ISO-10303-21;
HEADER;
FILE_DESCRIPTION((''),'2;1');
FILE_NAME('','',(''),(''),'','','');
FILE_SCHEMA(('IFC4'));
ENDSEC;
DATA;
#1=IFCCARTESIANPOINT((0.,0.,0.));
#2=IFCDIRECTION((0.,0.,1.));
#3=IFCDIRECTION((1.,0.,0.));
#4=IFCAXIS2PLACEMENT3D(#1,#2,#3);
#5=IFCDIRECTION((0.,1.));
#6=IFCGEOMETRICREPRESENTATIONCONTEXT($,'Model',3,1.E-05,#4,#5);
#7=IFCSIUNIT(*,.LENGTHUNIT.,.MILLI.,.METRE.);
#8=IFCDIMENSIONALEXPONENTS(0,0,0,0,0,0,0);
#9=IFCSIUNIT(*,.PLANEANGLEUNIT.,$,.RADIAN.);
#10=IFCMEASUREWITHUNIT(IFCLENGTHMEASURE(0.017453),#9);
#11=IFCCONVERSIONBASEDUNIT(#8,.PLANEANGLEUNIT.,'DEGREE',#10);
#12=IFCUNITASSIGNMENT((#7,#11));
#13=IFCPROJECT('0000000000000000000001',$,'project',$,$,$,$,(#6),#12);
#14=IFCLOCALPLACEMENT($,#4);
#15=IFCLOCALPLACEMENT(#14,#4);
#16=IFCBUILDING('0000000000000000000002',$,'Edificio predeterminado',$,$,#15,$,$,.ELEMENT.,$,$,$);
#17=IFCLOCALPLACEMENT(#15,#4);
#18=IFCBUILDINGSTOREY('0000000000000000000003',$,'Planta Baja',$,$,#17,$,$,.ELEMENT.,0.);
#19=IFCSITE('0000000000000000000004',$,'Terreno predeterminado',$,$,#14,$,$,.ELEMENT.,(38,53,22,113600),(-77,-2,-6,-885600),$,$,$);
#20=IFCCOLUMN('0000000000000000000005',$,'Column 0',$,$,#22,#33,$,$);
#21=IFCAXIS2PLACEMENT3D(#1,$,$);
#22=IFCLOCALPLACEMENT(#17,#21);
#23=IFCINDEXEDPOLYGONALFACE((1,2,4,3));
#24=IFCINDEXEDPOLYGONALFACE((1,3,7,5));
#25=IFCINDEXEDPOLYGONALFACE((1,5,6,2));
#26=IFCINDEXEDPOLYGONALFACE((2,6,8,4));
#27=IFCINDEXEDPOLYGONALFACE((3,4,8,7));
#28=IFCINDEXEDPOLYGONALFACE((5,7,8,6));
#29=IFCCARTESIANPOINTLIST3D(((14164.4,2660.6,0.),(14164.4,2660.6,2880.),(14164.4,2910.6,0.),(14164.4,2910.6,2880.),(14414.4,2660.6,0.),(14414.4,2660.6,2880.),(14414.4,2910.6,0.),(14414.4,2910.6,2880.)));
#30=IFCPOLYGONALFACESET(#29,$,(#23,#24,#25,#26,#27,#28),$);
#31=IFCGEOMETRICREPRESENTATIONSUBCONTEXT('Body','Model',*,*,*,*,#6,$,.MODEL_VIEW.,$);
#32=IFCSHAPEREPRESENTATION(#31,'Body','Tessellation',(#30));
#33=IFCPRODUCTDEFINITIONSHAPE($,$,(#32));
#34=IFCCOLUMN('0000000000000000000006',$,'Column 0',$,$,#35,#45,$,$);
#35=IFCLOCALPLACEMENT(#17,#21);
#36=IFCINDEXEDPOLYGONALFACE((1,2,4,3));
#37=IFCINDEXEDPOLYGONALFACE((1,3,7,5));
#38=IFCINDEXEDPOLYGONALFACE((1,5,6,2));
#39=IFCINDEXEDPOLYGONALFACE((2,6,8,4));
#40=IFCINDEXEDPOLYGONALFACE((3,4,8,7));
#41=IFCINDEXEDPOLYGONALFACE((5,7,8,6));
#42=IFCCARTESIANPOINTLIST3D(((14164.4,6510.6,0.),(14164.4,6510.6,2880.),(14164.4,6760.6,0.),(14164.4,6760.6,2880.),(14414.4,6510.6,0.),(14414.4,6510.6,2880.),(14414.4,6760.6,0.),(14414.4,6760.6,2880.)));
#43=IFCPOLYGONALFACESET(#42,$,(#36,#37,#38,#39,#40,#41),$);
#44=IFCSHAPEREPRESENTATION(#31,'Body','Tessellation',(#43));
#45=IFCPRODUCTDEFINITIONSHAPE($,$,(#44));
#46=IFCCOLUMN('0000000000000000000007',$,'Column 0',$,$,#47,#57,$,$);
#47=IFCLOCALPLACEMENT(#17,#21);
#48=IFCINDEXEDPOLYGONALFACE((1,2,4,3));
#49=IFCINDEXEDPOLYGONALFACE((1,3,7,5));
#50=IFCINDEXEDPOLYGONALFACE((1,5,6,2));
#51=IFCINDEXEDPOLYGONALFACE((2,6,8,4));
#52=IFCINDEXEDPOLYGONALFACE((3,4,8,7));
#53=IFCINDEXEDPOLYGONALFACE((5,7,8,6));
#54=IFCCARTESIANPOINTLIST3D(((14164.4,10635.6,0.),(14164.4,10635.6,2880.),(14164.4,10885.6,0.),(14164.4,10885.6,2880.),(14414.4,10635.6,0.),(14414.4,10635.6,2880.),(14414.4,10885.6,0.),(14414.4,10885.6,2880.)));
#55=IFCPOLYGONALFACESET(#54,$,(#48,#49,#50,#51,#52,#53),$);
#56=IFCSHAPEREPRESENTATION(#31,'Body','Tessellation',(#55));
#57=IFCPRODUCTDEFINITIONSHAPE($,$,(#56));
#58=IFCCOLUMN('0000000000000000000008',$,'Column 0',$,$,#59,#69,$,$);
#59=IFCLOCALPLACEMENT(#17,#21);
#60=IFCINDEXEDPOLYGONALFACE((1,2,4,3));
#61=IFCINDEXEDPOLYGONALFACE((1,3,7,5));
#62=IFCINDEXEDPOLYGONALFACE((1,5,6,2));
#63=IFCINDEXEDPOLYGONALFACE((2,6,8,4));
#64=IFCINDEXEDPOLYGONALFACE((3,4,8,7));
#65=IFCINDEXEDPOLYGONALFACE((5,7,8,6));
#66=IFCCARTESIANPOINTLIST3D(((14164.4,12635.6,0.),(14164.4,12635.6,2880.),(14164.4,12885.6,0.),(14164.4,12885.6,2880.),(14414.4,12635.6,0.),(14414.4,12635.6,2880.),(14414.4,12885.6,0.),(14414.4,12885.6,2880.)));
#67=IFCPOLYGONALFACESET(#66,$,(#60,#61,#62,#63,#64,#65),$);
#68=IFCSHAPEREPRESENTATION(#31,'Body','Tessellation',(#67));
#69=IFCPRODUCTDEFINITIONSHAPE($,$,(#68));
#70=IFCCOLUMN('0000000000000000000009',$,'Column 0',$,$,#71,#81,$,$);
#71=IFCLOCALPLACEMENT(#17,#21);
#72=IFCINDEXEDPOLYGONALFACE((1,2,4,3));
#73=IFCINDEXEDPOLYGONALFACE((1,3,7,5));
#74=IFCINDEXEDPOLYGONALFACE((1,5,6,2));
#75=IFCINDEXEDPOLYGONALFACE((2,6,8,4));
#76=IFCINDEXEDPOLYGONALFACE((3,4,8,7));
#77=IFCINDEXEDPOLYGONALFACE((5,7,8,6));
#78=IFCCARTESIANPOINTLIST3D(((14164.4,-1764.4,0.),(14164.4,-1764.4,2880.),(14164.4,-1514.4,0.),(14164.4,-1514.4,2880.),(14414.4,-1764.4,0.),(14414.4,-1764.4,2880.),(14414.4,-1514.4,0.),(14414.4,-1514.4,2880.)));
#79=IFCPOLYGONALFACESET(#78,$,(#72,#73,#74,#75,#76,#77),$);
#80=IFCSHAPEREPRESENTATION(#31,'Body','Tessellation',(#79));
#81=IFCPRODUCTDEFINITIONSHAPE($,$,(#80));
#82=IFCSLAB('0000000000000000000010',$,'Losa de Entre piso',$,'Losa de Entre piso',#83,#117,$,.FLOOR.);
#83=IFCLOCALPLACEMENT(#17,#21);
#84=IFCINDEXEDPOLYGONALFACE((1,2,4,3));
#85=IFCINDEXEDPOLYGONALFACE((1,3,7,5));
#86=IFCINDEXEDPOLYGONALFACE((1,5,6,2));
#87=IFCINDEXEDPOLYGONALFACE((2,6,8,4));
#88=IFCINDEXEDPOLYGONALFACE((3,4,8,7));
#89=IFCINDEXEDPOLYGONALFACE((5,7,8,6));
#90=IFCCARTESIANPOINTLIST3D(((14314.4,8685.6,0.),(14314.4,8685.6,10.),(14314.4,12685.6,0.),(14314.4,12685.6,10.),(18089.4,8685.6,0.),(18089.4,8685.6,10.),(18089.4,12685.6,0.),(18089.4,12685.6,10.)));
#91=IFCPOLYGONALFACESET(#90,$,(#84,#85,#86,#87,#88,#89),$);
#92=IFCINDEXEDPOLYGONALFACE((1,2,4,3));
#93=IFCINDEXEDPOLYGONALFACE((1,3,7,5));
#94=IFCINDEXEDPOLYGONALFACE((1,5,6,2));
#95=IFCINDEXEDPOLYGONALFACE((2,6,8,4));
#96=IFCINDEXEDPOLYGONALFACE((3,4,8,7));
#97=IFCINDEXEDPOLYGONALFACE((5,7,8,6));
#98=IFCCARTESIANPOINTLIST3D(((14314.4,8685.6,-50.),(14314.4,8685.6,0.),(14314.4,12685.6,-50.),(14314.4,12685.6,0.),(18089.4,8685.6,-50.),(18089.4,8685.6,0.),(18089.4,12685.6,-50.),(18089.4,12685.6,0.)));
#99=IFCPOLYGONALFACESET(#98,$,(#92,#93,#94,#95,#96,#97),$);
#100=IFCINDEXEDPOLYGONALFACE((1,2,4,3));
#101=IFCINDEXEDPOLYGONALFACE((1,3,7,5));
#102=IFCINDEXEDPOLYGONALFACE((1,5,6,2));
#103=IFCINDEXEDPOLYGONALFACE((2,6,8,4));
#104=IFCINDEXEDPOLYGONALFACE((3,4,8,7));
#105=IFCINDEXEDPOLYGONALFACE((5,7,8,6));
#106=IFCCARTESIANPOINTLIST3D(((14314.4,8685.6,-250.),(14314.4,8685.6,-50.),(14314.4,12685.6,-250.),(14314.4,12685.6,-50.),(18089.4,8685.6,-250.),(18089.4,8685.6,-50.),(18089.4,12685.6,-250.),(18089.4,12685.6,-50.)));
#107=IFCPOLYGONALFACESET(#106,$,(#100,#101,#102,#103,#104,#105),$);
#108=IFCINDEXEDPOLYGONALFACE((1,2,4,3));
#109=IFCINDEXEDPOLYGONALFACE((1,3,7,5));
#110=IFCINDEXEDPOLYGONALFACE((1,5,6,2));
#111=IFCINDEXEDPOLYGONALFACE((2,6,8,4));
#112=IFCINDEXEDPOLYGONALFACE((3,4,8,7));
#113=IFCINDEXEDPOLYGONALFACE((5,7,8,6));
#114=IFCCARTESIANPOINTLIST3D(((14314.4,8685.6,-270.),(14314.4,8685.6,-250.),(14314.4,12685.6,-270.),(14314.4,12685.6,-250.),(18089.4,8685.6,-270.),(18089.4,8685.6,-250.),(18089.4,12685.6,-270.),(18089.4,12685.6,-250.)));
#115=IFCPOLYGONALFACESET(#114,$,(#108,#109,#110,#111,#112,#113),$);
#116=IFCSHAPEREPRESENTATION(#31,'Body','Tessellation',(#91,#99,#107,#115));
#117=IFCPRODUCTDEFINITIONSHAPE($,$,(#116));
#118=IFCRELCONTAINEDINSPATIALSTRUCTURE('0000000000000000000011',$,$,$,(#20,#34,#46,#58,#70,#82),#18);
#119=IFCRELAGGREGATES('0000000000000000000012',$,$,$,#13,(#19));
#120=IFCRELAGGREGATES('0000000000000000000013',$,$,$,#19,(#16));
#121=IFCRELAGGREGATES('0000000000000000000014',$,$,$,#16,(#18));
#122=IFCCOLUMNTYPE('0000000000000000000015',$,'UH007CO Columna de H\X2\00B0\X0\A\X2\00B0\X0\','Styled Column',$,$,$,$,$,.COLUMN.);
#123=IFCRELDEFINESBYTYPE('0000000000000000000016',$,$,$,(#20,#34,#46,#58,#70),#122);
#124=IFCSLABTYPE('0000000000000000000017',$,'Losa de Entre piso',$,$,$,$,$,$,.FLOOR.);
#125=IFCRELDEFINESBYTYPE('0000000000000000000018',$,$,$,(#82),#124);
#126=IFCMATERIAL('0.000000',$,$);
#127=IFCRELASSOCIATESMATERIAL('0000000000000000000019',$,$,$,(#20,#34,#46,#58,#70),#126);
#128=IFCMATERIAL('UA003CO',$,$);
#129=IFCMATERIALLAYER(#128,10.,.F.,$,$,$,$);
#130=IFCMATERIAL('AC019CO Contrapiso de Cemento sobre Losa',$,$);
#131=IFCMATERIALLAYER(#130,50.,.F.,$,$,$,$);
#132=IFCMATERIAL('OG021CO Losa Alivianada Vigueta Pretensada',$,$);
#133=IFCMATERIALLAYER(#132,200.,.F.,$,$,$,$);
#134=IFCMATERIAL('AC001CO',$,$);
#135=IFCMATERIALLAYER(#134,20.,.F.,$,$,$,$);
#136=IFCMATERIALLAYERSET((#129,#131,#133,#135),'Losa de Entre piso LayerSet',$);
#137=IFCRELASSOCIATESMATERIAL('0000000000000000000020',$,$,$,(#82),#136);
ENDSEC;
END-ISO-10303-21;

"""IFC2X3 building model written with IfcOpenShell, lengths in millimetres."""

from ifc_helpers import new_model, entity, si_unit, converted_unit, direction, frame, origin_with_axes, place, context, subcontext, project, spatial, polyline, outline, extrude, material, layer, layer_set, layer_usage, type_object, element, save


model = new_model("IFC2X3")

# Units and contexts
model_context = context("Model", 3, precision=1e-05, world=origin_with_axes(), true_north=direction((0.0, 1.0)))
body_context = subcontext(model_context, "Body", "Model", "MODEL_VIEW")
ifc_project = project(units=[si_unit("LENGTHUNIT", "METRE", prefix="MILLI"), converted_unit("PLANEANGLEUNIT", "DEGREE", entity("IfcLengthMeasure", 0.017453), si_unit("PLANEANGLEUNIT", "RADIAN"), dimensions=[0, 0, 0, 0, 0, 0, 0])], contexts=[model_context])

# Site, building, storey
site_placement = place(None, origin_with_axes())
site = spatial("IfcSite", under=ifc_project, at=site_placement, Name="Terreno predeterminado", CompositionType="ELEMENT", RefLatitude=(38, 53, 22, 113600), RefLongitude=(-77, -2, -6, -885600))
building_placement = place(site_placement, origin_with_axes())
building = spatial("IfcBuilding", under=site, at=building_placement, Name="Edificio predeterminado", CompositionType="ELEMENT")
storey_placement = place(building_placement, origin_with_axes())
storey = spatial("IfcBuildingStorey", under=building, at=storey_placement, Name="Planta Baja", CompositionType="ELEMENT", Elevation=0.0)

# Columns
ifc_material_1 = material(Name="0.000000")
column_type = type_object("IfcColumnType", Name="UH007CO Columna de H°A°", Description="Styled Column", PredefinedType="COLUMN")
for number, where, z_axis, x_axis, name in (
    (1, (14289.4, 2785.6, 0.0), (0.0, 0.0, 1.0), (1.0, 0.0, 0.0), "Column 0"),
    (2, (14289.4, 6635.6, 0.0), (0.0, 0.0, 1.0), (1.0, 0.0, 0.0), "Column 0"),
    (3, (14289.4, 10760.6, 0.0), (0.0, 0.0, 1.0), (1.0, 0.0, 0.0), "Column 0"),
    (4, (14289.4, 12760.6, 0.0), (0.0, 0.0, 1.0), (1.0, 0.0, 0.0), "Column 0"),
    (5, (14289.4, -1639.4, 0.0), (0.0, 0.0, 1.0), (1.0, 0.0, 0.0), "Column 0"),
):
    element("IfcColumn", number, at=place(storey_placement, frame(where, z_axis=z_axis, x_axis=x_axis)), inside=storey, type_object=column_type, material=ifc_material_1, Name=name, context=body_context, shape_type="SweptSolid", body=[
        extrude(outline(polyline([(-125.0, -125.0), (125.0, -125.0), (125.0, 125.0), (-125.0, 125.0), (-125.0, -125.0)])), origin_with_axes(), (0.0, 0.0, 1.0), 2880.0),
    ])

# Slab
ifc_material_2 = material(Name="UA003CO")
ifc_layer_1 = layer(ifc_material_2, 10.0, ventilated=False)
ifc_material_3 = material(Name="AC019CO Contrapiso de Cemento sobre Losa")
ifc_layer_2 = layer(ifc_material_3, 50.0, ventilated=False)
ifc_material_4 = material(Name="OG021CO Losa Alivianada Vigueta Pretensada")
ifc_layer_3 = layer(ifc_material_4, 200.0, ventilated=False)
ifc_material_5 = material(Name="AC001CO")
ifc_layer_4 = layer(ifc_material_5, 20.0, ventilated=False)
ifc_layer_set_1 = layer_set([ifc_layer_1, ifc_layer_2, ifc_layer_3, ifc_layer_4], Name="Losa de Entre piso LayerSet")
ifc_layer_usage_1 = layer_usage(ifc_layer_set_1, "AXIS3", "NEGATIVE", 0.0)
slab_type = type_object("IfcSlabType", Name="Losa de Entre piso", PredefinedType="FLOOR")
slab_1_placement = place(storey_placement, origin_with_axes())
element("IfcSlab", 6, at=slab_1_placement, inside=storey, type_object=slab_type, material=ifc_layer_usage_1, Name="Losa de Entre piso", ObjectType="Losa de Entre piso", PredefinedType="FLOOR", context=body_context, shape_type="SweptSolid", body=[
    extrude(outline(polyline([(0.0, 4000.0), (3775.0, 4000.0), (3775.0, 0.0), (0.0, 0.0), (0.0, 4000.0)])), frame((14314.4, 12685.6, 0.0), z_axis=(0.0, 0.0, -1.0), x_axis=(1.0, 0.0, 0.0)), (0.0, 0.0, -1.0), 10.0),
    extrude(outline(polyline([(0.0, 4000.0), (3775.0, 4000.0), (3775.0, 0.0), (0.0, 0.0), (0.0, 4000.0)])), frame((14314.4, 12685.6, -50.0), z_axis=(0.0, 0.0, -1.0), x_axis=(1.0, 0.0, 0.0)), (0.0, 0.0, -1.0), 50.0),
    extrude(outline(polyline([(0.0, 4000.0), (3775.0, 4000.0), (3775.0, 0.0), (0.0, 0.0), (0.0, 4000.0)])), frame((14314.4, 12685.6, -250.0), z_axis=(0.0, 0.0, -1.0), x_axis=(1.0, 0.0, 0.0)), (0.0, 0.0, -1.0), 200.0),
    extrude(outline(polyline([(0.0, 4000.0), (3775.0, 4000.0), (3775.0, 0.0), (0.0, 0.0), (0.0, 4000.0)])), frame((14314.4, 12685.6, -270.0), z_axis=(0.0, 0.0, -1.0), x_axis=(1.0, 0.0, 0.0)), (0.0, 0.0, -1.0), 20.0),
])

save(model, "model.ifc")
